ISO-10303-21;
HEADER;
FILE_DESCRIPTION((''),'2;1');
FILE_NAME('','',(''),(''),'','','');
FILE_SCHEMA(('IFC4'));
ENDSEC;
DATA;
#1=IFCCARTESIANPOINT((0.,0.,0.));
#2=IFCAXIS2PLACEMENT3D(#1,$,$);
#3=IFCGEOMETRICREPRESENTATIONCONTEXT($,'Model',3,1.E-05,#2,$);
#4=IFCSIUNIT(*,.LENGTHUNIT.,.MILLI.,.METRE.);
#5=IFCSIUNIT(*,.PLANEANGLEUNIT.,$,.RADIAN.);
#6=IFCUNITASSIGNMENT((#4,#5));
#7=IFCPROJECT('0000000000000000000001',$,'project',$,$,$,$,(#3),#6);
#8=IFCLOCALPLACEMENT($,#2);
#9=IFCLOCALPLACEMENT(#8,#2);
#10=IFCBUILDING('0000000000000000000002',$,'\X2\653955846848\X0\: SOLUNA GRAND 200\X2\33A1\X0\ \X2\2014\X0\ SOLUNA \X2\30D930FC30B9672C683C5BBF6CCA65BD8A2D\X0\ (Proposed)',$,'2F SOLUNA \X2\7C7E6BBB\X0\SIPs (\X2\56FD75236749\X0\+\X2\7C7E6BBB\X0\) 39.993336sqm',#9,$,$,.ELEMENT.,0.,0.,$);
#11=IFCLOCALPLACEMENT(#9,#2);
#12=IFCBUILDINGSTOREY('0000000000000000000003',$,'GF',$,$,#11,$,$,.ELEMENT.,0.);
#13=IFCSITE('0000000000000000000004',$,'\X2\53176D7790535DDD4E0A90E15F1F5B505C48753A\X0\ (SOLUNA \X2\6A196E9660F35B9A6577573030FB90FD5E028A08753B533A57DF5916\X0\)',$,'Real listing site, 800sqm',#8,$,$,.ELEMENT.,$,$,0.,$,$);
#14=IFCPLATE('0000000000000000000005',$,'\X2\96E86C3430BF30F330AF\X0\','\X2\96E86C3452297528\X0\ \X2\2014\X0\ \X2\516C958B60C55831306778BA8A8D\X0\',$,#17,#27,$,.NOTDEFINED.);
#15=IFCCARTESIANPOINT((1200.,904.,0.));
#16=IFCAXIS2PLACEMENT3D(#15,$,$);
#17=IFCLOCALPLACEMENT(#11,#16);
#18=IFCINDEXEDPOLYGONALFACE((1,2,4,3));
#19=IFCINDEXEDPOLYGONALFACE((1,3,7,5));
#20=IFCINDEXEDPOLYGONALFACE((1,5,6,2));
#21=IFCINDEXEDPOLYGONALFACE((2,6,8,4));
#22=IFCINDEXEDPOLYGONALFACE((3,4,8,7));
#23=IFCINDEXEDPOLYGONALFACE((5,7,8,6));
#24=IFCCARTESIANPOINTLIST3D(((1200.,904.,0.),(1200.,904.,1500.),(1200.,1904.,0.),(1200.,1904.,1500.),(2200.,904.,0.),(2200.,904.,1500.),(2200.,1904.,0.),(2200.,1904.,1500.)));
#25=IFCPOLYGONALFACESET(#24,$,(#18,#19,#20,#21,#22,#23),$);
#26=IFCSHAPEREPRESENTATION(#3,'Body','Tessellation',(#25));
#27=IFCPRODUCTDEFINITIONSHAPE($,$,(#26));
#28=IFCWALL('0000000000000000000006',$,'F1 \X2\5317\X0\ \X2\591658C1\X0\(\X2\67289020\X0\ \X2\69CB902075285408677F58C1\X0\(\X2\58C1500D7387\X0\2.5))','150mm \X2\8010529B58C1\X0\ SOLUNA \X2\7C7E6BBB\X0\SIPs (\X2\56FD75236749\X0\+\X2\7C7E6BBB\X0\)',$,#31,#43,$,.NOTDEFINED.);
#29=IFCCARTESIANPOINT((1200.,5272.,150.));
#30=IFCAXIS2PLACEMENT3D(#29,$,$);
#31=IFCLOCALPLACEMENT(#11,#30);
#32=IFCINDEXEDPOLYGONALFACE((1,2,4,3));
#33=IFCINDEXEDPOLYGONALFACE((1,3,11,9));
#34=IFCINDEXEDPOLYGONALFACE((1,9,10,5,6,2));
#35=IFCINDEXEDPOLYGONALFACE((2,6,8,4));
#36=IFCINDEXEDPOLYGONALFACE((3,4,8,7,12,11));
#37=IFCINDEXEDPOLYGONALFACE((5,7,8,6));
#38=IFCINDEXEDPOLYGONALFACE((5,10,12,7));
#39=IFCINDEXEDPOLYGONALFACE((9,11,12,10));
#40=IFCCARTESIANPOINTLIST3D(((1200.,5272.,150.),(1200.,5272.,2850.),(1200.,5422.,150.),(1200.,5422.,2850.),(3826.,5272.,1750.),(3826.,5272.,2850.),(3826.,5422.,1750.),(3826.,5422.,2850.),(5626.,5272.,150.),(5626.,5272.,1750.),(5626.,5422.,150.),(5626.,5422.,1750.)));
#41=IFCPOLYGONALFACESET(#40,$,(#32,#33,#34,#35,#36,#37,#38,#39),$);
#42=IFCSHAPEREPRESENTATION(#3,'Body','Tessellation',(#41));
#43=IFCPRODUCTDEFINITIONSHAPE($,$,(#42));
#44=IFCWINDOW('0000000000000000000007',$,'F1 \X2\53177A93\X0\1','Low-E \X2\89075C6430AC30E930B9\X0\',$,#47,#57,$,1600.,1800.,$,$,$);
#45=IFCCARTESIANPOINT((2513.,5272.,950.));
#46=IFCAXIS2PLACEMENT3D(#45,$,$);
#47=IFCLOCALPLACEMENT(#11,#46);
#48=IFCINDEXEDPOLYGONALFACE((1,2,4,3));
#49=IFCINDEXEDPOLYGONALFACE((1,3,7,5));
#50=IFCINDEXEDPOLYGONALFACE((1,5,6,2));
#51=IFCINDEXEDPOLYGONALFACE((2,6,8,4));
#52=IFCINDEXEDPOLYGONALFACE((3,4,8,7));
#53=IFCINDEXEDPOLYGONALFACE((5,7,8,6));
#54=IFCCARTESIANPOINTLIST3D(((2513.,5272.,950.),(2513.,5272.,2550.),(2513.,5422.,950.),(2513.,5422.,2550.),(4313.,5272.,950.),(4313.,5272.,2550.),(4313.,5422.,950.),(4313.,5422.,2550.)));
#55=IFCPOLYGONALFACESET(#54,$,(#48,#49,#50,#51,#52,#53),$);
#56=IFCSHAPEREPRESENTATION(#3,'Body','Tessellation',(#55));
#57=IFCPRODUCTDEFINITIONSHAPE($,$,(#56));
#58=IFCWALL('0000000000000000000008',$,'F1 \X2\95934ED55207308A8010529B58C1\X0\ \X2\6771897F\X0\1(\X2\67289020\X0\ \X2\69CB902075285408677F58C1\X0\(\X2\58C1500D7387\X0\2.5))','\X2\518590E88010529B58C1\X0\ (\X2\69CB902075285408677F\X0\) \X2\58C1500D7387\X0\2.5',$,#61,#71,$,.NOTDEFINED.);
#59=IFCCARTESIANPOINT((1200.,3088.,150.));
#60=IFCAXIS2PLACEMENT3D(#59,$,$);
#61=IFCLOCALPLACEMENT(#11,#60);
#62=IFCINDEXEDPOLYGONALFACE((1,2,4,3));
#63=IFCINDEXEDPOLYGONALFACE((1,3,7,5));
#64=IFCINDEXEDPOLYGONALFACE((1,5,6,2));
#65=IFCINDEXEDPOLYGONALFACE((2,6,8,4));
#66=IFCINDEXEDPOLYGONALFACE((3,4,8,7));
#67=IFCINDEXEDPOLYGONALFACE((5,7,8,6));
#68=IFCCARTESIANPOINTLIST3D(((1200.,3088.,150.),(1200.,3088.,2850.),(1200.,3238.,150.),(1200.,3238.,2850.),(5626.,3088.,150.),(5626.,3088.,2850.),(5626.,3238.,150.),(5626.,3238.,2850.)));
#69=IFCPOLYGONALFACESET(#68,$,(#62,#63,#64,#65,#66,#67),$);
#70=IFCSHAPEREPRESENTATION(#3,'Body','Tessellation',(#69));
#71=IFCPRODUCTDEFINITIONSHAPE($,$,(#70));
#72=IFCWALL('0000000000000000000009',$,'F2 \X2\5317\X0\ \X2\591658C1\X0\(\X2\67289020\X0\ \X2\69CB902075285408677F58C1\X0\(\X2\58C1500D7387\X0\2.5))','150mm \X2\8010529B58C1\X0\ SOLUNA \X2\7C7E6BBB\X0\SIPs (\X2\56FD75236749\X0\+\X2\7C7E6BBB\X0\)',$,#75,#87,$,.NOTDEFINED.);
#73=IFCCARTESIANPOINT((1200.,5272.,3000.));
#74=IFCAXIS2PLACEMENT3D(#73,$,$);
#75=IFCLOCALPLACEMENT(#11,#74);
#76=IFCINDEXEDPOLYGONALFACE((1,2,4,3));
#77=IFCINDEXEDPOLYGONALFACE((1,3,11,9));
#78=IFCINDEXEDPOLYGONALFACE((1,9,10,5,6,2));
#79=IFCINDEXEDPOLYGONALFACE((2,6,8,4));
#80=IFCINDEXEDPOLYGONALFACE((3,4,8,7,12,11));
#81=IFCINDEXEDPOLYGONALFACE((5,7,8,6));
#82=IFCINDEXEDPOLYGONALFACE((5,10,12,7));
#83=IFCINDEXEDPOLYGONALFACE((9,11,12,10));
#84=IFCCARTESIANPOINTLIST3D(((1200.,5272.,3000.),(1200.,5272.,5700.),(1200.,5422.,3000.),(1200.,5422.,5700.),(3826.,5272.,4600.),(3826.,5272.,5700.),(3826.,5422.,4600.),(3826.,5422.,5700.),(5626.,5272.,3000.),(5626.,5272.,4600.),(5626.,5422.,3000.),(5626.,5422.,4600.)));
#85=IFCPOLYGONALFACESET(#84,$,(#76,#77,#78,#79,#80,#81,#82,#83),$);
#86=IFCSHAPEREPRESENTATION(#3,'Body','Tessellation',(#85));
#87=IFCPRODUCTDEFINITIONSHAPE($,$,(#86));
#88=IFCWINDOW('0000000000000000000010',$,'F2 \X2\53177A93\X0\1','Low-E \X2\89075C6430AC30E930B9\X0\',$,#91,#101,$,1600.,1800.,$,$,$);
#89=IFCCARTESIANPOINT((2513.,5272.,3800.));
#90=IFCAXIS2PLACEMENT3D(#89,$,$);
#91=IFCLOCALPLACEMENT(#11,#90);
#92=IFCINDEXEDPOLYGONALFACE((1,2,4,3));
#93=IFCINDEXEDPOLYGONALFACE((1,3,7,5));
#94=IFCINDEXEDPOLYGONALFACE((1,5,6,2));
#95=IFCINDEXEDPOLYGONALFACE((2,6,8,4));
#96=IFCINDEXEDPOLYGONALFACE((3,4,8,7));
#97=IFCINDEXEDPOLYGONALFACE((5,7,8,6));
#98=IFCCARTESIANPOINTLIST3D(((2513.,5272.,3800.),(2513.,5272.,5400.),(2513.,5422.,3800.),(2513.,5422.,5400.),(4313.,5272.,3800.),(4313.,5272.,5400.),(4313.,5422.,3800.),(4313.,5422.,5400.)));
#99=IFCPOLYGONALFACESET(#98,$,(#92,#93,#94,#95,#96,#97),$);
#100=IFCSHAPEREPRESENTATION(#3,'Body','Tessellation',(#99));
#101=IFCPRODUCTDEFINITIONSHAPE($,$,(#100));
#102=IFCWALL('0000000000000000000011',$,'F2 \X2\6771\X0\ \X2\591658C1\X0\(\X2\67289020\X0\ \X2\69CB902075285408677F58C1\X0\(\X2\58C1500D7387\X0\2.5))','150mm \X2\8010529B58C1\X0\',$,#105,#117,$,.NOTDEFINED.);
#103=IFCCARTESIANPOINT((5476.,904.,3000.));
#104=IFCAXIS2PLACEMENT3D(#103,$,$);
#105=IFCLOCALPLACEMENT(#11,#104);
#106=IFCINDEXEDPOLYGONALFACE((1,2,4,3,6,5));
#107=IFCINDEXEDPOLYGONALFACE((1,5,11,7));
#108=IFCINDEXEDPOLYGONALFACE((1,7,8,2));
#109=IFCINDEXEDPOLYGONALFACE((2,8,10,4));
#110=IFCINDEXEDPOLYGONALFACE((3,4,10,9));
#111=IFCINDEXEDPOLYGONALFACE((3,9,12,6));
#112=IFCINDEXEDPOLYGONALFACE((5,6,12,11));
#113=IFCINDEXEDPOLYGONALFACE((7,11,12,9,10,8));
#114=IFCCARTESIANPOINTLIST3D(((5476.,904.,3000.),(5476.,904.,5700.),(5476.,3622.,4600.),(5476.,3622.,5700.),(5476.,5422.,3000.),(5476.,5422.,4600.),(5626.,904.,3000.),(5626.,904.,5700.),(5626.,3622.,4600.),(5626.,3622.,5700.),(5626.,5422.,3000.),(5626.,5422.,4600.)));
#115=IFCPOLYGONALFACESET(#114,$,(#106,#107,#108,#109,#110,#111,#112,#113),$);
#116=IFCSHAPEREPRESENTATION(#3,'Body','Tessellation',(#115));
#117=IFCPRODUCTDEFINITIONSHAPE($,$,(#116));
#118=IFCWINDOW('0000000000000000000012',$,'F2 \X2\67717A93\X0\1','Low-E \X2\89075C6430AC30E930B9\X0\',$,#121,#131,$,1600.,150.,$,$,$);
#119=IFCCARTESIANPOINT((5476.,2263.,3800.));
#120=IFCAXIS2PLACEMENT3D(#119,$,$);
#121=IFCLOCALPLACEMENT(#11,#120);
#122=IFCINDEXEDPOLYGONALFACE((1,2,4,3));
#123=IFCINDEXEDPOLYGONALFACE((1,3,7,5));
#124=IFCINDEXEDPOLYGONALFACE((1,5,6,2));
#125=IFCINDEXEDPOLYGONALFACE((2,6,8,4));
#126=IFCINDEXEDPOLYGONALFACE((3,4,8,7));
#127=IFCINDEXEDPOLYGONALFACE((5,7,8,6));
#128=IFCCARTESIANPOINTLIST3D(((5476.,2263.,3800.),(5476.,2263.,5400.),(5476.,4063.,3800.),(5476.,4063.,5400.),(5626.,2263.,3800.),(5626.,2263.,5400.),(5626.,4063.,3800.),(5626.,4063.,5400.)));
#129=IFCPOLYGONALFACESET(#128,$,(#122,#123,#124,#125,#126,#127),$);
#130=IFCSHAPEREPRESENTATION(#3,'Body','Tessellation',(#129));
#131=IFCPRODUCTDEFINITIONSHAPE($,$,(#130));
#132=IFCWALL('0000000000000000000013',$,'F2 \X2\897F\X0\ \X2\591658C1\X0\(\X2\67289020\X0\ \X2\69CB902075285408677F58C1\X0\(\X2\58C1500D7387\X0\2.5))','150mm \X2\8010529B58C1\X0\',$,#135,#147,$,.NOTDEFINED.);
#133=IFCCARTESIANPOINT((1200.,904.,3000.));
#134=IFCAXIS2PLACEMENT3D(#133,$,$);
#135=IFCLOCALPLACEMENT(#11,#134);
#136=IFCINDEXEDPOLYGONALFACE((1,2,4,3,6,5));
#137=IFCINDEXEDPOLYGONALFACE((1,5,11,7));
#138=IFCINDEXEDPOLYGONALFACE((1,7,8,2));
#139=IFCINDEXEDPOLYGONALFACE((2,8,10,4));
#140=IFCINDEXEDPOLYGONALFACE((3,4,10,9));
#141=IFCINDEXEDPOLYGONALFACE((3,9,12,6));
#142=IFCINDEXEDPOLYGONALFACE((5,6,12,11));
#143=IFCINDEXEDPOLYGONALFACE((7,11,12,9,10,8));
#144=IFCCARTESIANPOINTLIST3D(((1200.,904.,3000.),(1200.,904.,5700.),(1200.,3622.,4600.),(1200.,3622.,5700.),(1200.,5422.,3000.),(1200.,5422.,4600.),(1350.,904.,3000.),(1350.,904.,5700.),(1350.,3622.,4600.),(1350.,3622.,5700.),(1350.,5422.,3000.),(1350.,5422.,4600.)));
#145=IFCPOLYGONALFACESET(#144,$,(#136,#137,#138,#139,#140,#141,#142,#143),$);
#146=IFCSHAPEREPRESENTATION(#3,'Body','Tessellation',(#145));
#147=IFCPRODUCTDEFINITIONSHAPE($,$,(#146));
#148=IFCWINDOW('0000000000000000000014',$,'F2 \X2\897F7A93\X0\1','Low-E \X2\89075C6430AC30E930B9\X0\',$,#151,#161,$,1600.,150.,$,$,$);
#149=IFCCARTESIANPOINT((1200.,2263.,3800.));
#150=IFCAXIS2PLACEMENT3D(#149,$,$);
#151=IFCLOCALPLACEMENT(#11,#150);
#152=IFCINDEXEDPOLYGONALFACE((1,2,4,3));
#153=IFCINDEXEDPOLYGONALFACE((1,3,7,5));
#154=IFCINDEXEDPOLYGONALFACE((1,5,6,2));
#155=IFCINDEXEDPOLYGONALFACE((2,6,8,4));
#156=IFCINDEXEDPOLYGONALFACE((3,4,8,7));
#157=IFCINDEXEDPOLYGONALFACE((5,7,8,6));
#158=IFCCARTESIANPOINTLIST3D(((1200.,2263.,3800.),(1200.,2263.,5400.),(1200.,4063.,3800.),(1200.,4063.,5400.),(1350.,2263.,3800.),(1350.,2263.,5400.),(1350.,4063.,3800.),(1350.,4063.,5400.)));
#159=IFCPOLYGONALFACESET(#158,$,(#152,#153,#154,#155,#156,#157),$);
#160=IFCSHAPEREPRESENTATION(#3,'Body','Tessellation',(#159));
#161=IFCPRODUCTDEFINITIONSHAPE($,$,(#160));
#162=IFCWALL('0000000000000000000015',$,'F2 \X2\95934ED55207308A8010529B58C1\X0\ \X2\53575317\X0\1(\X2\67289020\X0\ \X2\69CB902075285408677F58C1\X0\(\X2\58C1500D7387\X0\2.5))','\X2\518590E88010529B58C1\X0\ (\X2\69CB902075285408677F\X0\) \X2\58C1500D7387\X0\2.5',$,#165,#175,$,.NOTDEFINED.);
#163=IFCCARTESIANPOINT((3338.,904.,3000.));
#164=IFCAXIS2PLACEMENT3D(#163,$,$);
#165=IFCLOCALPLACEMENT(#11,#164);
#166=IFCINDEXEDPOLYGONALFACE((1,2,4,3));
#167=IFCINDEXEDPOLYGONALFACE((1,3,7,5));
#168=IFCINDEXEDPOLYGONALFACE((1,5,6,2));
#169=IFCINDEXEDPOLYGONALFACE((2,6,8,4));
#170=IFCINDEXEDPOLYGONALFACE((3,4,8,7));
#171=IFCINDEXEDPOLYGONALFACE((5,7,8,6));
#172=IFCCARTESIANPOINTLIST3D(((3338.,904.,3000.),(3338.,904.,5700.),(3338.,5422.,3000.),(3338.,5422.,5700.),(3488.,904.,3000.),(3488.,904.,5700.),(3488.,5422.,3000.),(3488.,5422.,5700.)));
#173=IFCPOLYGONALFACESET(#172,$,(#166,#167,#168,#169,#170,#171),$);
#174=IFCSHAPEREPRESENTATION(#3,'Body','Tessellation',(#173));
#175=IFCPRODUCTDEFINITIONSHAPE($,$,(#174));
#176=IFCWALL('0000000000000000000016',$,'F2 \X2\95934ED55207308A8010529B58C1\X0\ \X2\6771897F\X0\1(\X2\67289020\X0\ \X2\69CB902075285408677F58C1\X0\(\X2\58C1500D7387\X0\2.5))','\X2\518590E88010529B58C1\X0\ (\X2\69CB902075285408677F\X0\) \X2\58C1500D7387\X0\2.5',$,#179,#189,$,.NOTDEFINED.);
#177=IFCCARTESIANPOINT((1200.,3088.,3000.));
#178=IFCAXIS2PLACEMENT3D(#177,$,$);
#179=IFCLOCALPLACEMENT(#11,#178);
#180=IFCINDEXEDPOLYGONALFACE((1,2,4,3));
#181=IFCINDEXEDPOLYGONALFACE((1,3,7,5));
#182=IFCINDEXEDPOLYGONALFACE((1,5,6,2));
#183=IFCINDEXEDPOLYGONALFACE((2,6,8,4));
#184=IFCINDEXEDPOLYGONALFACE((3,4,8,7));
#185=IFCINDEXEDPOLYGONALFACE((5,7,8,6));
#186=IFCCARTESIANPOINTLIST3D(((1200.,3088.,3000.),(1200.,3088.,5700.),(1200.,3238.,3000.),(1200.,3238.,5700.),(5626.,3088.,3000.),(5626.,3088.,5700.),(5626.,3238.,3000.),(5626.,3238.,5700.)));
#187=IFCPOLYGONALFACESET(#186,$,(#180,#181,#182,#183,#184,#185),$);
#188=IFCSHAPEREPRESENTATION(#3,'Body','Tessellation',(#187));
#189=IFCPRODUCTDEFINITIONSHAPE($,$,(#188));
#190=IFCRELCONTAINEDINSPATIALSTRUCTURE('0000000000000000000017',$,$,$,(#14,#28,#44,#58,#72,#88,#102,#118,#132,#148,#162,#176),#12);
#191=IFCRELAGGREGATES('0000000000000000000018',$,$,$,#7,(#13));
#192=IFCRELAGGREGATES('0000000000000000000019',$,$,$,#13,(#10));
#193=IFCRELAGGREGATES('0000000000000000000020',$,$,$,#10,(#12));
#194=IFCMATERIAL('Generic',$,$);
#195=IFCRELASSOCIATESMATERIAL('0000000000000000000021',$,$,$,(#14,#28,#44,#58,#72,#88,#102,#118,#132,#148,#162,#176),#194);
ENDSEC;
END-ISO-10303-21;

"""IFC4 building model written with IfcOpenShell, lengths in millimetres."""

from ifc_helpers import new_model, si_unit, frame, frame_2d, origin, place, context, project, spatial, rectangle, extrude, material, element, fill, save


model = new_model("IFC4")

# Units and contexts
model_context = context("Model", 3, precision=1e-05, world=origin())
ifc_project = project(units=[si_unit("LENGTHUNIT", "METRE", prefix="MILLI"), si_unit("PLANEANGLEUNIT", "RADIAN")], contexts=[model_context])

# Site, building, storey
site_placement = place(None, origin())
site = spatial("IfcSite", under=ifc_project, at=site_placement, Name="北海道川上郡弟子屈町 (SOLUNA 標準想定敷地・都市計画区域外)", ObjectType="Real listing site, 800sqm", CompositionType="ELEMENT", RefElevation=0.0)
building_placement = place(site_placement, origin())
building = spatial("IfcBuilding", under=site, at=building_placement, Name="改善案: SOLUNA GRAND 200㎡ — SOLUNA ベース本格宿泊施設 (Proposed)", ObjectType="2F SOLUNA 籾殻SIPs (国産杉+籾殻) 39.993336sqm", CompositionType="ELEMENT", ElevationOfRefHeight=0.0, ElevationOfTerrain=0.0)
storey_placement = place(building_placement, origin())
storey = spatial("IfcBuildingStorey", under=building, at=storey_placement, Name="GF", CompositionType="ELEMENT", Elevation=0.0)

# Plate
ifc_material_1 = material(Name="Generic")
plate_placement = place(storey_placement, frame((1200.0, 904.0, 0.0)))
element("IfcPlate", 1, at=plate_placement, inside=storey, material=ifc_material_1, Name="雨水タンク", Description="雨水利用 — 公開情報で確認", PredefinedType="NOTDEFINED", context=model_context, shape_type="SweptSolid", body=[
    extrude(rectangle(XDim=1000.0, YDim=1000.0, at=frame_2d((500.0, 500.0))), frame((1200.0, 904.0, 0.0)), (0.0, 0.0, 1.0), 1500.0),
])

# Wall, opening, window
wall_1_placement = place(storey_placement, frame((1200.0, 5272.0, 150.0)))
wall_1 = element("IfcWall", 2, at=wall_1_placement, inside=storey, material=ifc_material_1, Name="F1 北 外壁(木造 構造用合板壁(壁倍率2.5))", Description="150mm 耐力壁 SOLUNA 籾殻SIPs (国産杉+籾殻)", PredefinedType="NOTDEFINED", context=model_context, shape_type="SweptSolid", body=[
    extrude(rectangle(XDim=4426.0, YDim=150.0, at=frame_2d((2213.0, 75.0))), frame((1200.0, 5272.0, 150.0)), (0.0, 0.0, 1.0), 2700.0),
])
opening_1_placement = place(storey_placement, frame((2513.0, 5272.0, 950.0)))
opening_1 = element("IfcOpeningElement", 3, at=opening_1_placement, cuts=wall_1, PredefinedType="NOTDEFINED", context=model_context, shape_type="SweptSolid", body=[
    extrude(rectangle(XDim=1800.0, YDim=150.0, at=frame_2d((900.0, 75.0))), frame((2513.0, 5272.0, 950.0)), (0.0, 0.0, 1.0), 1600.0),
])
window_1_placement = place(storey_placement, frame((2513.0, 5272.0, 950.0)))
window_1 = element("IfcWindow", 4, at=window_1_placement, inside=storey, material=ifc_material_1, Name="F1 北窓1", Description="Low-E 複層ガラス", OverallHeight=1600.0, OverallWidth=1800.0, context=model_context, shape_type="SweptSolid", body=[
    extrude(rectangle(XDim=1800.0, YDim=150.0, at=frame_2d((900.0, 75.0))), frame((2513.0, 5272.0, 950.0)), (0.0, 0.0, 1.0), 1600.0),
])
fill(opening_1, window_1)

# Wall
wall_2_placement = place(storey_placement, frame((1200.0, 3088.0, 150.0)))
element("IfcWall", 5, at=wall_2_placement, inside=storey, material=ifc_material_1, Name="F1 間仕切り耐力壁 東西1(木造 構造用合板壁(壁倍率2.5))", Description="内部耐力壁 (構造用合板) 壁倍率2.5", PredefinedType="NOTDEFINED", context=model_context, shape_type="SweptSolid", body=[
    extrude(rectangle(XDim=4426.0, YDim=150.0, at=frame_2d((2213.0, 75.0))), frame((1200.0, 3088.0, 150.0)), (0.0, 0.0, 1.0), 2700.0),
])

# Walls, openings, windows
wall_3_placement = place(storey_placement, frame((1200.0, 5272.0, 3000.0)))
wall_3 = element("IfcWall", 6, at=wall_3_placement, inside=storey, material=ifc_material_1, Name="F2 北 外壁(木造 構造用合板壁(壁倍率2.5))", Description="150mm 耐力壁 SOLUNA 籾殻SIPs (国産杉+籾殻)", PredefinedType="NOTDEFINED", context=model_context, shape_type="SweptSolid", body=[
    extrude(rectangle(XDim=4426.0, YDim=150.0, at=frame_2d((2213.0, 75.0))), frame((1200.0, 5272.0, 3000.0)), (0.0, 0.0, 1.0), 2700.0),
])
opening_2_placement = place(storey_placement, frame((2513.0, 5272.0, 3800.0)))
opening_2 = element("IfcOpeningElement", 7, at=opening_2_placement, cuts=wall_3, PredefinedType="NOTDEFINED", context=model_context, shape_type="SweptSolid", body=[
    extrude(rectangle(XDim=1800.0, YDim=150.0, at=frame_2d((900.0, 75.0))), frame((2513.0, 5272.0, 3800.0)), (0.0, 0.0, 1.0), 1600.0),
])
window_2_placement = place(storey_placement, frame((2513.0, 5272.0, 3800.0)))
window_2 = element("IfcWindow", 8, at=window_2_placement, inside=storey, material=ifc_material_1, Name="F2 北窓1", Description="Low-E 複層ガラス", OverallHeight=1600.0, OverallWidth=1800.0, context=model_context, shape_type="SweptSolid", body=[
    extrude(rectangle(XDim=1800.0, YDim=150.0, at=frame_2d((900.0, 75.0))), frame((2513.0, 5272.0, 3800.0)), (0.0, 0.0, 1.0), 1600.0),
])
fill(opening_2, window_2)
wall_4_placement = place(storey_placement, frame((5476.0, 904.0, 3000.0)))
wall_4 = element("IfcWall", 9, at=wall_4_placement, inside=storey, material=ifc_material_1, Name="F2 東 外壁(木造 構造用合板壁(壁倍率2.5))", Description="150mm 耐力壁", PredefinedType="NOTDEFINED", context=model_context, shape_type="SweptSolid", body=[
    extrude(rectangle(XDim=150.0, YDim=4518.0, at=frame_2d((75.0, 2259.0))), frame((5476.0, 904.0, 3000.0)), (0.0, 0.0, 1.0), 2700.0),
])
opening_3_placement = place(storey_placement, frame((5476.0, 2263.0, 3800.0)))
opening_3 = element("IfcOpeningElement", 10, at=opening_3_placement, cuts=wall_4, PredefinedType="NOTDEFINED", context=model_context, shape_type="SweptSolid", body=[
    extrude(rectangle(XDim=150.0, YDim=1800.0, at=frame_2d((75.0, 900.0))), frame((5476.0, 2263.0, 3800.0)), (0.0, 0.0, 1.0), 1600.0),
])
window_3_placement = place(storey_placement, frame((5476.0, 2263.0, 3800.0)))
window_3 = element("IfcWindow", 11, at=window_3_placement, inside=storey, material=ifc_material_1, Name="F2 東窓1", Description="Low-E 複層ガラス", OverallHeight=1600.0, OverallWidth=150.0, context=model_context, shape_type="SweptSolid", body=[
    extrude(rectangle(XDim=150.0, YDim=1800.0, at=frame_2d((75.0, 900.0))), frame((5476.0, 2263.0, 3800.0)), (0.0, 0.0, 1.0), 1600.0),
])
fill(opening_3, window_3)
wall_5_placement = place(storey_placement, frame((1200.0, 904.0, 3000.0)))
wall_5 = element("IfcWall", 12, at=wall_5_placement, inside=storey, material=ifc_material_1, Name="F2 西 外壁(木造 構造用合板壁(壁倍率2.5))", Description="150mm 耐力壁", PredefinedType="NOTDEFINED", context=model_context, shape_type="SweptSolid", body=[
    extrude(rectangle(XDim=150.0, YDim=4518.0, at=frame_2d((75.0, 2259.0))), frame((1200.0, 904.0, 3000.0)), (0.0, 0.0, 1.0), 2700.0),
])
opening_4_placement = place(storey_placement, frame((1200.0, 2263.0, 3800.0)))
opening_4 = element("IfcOpeningElement", 13, at=opening_4_placement, cuts=wall_5, PredefinedType="NOTDEFINED", context=model_context, shape_type="SweptSolid", body=[
    extrude(rectangle(XDim=150.0, YDim=1800.0, at=frame_2d((75.0, 900.0))), frame((1200.0, 2263.0, 3800.0)), (0.0, 0.0, 1.0), 1600.0),
])
window_4_placement = place(storey_placement, frame((1200.0, 2263.0, 3800.0)))
window_4 = element("IfcWindow", 14, at=window_4_placement, inside=storey, material=ifc_material_1, Name="F2 西窓1", Description="Low-E 複層ガラス", OverallHeight=1600.0, OverallWidth=150.0, context=model_context, shape_type="SweptSolid", body=[
    extrude(rectangle(XDim=150.0, YDim=1800.0, at=frame_2d((75.0, 900.0))), frame((1200.0, 2263.0, 3800.0)), (0.0, 0.0, 1.0), 1600.0),
])
fill(opening_4, window_4)

# Walls
wall_6_placement = place(storey_placement, frame((3338.0, 904.0, 3000.0)))
element("IfcWall", 15, at=wall_6_placement, inside=storey, material=ifc_material_1, Name="F2 間仕切り耐力壁 南北1(木造 構造用合板壁(壁倍率2.5))", Description="内部耐力壁 (構造用合板) 壁倍率2.5", PredefinedType="NOTDEFINED", context=model_context, shape_type="SweptSolid", body=[
    extrude(rectangle(XDim=150.0, YDim=4518.0, at=frame_2d((75.0, 2259.0))), frame((3338.0, 904.0, 3000.0)), (0.0, 0.0, 1.0), 2700.0),
])
wall_7_placement = place(storey_placement, frame((1200.0, 3088.0, 3000.0)))
element("IfcWall", 16, at=wall_7_placement, inside=storey, material=ifc_material_1, Name="F2 間仕切り耐力壁 東西1(木造 構造用合板壁(壁倍率2.5))", Description="内部耐力壁 (構造用合板) 壁倍率2.5", PredefinedType="NOTDEFINED", context=model_context, shape_type="SweptSolid", body=[
    extrude(rectangle(XDim=4426.0, YDim=150.0, at=frame_2d((2213.0, 75.0))), frame((1200.0, 3088.0, 3000.0)), (0.0, 0.0, 1.0), 2700.0),
])

save(model, "model.ifc")
